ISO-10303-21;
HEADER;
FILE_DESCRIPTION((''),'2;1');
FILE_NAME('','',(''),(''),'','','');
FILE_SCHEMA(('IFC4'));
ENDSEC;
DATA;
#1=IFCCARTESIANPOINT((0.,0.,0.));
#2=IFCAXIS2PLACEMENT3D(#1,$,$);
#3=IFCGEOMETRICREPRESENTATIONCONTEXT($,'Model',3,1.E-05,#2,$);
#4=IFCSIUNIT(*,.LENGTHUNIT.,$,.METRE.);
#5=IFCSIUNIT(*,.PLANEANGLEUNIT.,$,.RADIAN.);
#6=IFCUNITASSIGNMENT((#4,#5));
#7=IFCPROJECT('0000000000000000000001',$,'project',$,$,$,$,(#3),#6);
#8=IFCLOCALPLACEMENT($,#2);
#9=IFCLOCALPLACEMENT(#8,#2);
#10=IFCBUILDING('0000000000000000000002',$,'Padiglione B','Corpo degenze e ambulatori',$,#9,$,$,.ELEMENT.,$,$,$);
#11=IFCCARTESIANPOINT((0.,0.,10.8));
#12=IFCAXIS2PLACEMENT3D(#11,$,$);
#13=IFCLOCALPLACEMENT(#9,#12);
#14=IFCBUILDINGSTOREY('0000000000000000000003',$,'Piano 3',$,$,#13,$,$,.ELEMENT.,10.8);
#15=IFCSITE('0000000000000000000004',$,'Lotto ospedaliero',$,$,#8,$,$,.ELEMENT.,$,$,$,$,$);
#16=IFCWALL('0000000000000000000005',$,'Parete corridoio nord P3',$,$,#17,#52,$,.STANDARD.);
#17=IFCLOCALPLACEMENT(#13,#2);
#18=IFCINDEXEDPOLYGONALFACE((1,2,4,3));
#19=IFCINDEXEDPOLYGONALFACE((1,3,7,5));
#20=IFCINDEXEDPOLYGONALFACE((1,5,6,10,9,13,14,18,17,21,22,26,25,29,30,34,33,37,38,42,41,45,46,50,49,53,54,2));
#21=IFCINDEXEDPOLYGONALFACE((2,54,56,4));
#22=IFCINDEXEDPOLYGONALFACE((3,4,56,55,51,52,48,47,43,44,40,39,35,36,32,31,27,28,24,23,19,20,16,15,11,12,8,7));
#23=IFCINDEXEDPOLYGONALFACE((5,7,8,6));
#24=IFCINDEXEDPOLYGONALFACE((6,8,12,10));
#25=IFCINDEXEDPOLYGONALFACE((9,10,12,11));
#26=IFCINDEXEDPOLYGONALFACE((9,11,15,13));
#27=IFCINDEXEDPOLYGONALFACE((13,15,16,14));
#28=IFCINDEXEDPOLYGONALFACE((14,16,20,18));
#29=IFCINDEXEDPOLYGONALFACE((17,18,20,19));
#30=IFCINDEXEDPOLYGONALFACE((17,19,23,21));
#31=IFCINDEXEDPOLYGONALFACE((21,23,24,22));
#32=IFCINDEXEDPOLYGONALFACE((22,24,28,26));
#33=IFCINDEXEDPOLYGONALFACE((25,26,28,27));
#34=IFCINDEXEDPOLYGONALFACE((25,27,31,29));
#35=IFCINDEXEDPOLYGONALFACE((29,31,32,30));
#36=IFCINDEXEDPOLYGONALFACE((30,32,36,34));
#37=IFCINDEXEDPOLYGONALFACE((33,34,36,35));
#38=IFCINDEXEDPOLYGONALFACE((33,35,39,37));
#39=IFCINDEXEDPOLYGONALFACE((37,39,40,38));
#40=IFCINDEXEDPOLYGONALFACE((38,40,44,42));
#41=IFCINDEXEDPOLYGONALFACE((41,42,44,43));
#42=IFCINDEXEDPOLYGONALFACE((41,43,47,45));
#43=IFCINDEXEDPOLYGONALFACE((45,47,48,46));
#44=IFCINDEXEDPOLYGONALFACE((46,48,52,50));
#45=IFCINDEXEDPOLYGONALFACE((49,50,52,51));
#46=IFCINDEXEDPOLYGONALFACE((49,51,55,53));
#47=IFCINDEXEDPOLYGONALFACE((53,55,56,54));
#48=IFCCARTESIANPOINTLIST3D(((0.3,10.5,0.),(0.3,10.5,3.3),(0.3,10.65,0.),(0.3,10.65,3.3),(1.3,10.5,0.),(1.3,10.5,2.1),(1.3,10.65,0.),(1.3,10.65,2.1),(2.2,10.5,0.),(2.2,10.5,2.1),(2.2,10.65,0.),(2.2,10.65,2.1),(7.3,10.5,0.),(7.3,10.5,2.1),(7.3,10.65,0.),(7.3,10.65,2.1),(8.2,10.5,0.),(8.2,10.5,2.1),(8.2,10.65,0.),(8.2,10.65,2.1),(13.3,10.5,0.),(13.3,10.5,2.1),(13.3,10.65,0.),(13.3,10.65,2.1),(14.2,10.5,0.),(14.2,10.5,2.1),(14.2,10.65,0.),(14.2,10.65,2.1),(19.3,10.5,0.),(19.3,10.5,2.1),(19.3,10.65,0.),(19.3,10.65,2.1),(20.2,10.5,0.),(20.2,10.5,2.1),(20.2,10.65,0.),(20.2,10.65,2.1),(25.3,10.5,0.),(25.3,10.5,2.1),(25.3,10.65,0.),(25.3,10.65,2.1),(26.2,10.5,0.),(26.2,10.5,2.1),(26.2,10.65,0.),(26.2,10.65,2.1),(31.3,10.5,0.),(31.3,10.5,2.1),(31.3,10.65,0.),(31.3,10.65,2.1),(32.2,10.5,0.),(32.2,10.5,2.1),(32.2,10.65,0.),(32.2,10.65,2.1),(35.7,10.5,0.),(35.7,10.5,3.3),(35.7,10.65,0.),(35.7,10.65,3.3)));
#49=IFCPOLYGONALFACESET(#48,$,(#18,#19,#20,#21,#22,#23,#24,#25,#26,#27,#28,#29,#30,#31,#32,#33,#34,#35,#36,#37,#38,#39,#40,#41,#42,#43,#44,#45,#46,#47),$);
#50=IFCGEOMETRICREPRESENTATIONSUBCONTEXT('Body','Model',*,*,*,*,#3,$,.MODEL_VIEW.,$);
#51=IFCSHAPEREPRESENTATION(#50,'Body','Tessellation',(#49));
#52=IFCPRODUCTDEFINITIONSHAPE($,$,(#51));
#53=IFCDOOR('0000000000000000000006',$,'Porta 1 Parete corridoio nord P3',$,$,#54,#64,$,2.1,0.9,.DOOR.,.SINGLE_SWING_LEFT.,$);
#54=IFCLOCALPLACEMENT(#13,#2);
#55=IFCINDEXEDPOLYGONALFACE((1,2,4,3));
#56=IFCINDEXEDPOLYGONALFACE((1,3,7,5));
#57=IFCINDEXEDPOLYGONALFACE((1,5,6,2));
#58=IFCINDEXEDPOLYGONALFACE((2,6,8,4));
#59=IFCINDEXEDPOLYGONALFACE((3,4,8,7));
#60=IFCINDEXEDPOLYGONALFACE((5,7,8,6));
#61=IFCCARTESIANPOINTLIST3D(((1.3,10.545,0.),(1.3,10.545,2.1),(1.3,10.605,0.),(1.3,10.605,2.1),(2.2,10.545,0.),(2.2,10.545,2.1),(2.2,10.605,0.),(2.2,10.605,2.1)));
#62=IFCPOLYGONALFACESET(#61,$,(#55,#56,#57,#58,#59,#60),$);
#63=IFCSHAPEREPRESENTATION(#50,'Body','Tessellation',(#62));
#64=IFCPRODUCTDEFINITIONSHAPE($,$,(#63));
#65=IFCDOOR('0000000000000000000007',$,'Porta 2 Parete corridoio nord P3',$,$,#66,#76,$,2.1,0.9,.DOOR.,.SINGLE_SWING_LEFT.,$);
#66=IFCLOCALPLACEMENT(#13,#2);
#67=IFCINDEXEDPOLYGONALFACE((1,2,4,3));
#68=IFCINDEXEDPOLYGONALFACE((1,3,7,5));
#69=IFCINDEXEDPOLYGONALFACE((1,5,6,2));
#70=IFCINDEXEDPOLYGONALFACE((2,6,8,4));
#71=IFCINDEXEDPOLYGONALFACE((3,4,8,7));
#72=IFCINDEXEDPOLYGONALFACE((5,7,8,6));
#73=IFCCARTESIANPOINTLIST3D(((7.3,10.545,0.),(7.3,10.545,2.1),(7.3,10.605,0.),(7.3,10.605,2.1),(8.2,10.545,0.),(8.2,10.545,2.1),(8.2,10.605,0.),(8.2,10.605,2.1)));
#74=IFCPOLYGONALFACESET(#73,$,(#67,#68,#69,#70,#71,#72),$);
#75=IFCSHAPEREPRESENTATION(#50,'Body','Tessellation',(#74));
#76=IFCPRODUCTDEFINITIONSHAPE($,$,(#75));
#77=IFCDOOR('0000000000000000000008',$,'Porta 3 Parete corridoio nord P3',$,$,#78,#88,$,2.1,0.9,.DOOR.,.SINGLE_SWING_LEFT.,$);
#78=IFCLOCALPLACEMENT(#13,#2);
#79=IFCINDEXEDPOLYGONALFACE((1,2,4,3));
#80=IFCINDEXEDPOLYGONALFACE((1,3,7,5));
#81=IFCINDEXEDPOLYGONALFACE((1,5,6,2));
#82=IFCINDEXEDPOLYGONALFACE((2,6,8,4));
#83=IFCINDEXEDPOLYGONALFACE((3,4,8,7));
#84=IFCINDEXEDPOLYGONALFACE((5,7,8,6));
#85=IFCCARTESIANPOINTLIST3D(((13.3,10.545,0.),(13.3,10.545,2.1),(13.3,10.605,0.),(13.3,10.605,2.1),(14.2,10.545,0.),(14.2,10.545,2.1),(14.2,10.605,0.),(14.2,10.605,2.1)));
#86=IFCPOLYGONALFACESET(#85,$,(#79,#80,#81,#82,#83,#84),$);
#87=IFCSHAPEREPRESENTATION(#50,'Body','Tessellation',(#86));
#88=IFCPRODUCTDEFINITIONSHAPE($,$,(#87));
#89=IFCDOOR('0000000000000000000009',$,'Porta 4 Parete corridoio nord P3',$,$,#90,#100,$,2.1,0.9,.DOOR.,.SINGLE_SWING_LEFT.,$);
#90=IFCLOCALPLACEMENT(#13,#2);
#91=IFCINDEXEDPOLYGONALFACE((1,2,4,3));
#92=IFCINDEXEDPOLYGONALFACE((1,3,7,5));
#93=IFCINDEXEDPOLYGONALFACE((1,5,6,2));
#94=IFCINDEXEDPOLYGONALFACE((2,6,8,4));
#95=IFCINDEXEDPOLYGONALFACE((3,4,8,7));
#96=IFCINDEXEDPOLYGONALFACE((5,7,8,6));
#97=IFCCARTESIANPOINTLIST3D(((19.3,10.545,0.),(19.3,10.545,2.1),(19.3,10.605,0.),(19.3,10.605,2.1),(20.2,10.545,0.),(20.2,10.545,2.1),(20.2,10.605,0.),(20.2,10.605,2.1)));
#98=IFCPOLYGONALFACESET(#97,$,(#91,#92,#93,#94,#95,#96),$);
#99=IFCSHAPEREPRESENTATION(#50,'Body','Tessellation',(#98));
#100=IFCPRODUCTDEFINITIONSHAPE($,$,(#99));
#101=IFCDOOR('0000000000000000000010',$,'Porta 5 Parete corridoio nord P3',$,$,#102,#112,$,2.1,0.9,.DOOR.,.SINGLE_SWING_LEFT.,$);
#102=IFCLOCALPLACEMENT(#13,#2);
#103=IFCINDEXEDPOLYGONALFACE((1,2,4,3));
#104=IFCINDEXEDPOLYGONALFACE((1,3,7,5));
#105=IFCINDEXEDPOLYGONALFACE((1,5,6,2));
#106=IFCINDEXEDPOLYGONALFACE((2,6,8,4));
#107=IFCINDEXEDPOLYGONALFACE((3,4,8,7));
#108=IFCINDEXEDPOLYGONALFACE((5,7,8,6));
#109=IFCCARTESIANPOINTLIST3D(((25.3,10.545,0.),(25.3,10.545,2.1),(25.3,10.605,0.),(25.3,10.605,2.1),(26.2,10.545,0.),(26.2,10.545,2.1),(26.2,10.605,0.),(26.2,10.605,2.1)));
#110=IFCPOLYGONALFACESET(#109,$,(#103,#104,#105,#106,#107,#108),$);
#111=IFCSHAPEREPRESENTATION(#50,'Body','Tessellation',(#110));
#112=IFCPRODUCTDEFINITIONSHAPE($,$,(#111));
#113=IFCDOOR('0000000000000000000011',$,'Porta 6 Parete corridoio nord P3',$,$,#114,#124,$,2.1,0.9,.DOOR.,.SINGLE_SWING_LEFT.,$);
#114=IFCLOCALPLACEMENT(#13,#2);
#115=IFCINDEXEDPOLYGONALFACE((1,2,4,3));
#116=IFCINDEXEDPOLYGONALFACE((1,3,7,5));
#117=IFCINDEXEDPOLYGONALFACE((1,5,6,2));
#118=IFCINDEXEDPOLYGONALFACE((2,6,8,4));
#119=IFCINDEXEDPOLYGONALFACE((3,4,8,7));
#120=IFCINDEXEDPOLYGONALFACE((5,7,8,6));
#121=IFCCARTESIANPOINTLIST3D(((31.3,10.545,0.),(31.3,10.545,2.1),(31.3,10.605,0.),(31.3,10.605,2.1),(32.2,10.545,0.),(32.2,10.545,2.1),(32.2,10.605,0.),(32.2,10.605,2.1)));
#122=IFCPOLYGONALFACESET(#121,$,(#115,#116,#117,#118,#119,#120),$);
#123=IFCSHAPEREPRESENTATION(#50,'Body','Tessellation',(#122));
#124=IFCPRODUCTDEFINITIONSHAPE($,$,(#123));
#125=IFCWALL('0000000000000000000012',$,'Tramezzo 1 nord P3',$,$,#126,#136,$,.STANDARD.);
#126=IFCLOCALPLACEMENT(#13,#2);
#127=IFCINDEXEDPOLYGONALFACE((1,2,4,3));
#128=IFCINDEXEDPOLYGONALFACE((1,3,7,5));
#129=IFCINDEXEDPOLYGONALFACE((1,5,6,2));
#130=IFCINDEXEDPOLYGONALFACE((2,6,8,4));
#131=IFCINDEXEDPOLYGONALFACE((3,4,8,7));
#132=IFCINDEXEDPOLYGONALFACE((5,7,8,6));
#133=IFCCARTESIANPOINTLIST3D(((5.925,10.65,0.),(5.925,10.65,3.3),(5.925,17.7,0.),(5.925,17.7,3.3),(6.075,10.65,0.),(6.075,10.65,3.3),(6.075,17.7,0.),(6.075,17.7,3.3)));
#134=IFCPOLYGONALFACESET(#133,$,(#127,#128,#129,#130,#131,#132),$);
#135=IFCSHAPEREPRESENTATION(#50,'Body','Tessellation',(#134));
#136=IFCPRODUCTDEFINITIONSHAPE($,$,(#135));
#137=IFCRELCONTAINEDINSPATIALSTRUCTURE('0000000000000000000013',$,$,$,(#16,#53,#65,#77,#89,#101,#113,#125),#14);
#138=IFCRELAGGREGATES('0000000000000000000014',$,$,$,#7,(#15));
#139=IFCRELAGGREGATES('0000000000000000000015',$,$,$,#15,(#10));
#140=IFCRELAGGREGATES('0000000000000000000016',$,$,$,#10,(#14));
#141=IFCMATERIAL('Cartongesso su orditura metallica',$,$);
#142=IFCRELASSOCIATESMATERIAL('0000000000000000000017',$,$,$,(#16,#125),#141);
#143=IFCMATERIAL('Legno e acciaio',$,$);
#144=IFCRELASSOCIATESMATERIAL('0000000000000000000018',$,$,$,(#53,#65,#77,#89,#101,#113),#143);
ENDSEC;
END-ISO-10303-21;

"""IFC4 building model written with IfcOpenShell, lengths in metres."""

from ifc_helpers import new_model, si_unit, frame, frame_2d, origin, place, context, subcontext, project, spatial, rectangle, extrude, material, element, fill, save


model = new_model("IFC4")

# Units and contexts
model_context = context("Model", 3, precision=1e-05, world=origin())
body_context = subcontext(model_context, "Body", "Model", "MODEL_VIEW")
ifc_project = project(units=[si_unit("LENGTHUNIT", "METRE"), si_unit("PLANEANGLEUNIT", "RADIAN")], contexts=[model_context])

# Site, building, storey
site_placement = place(None, origin())
site = spatial("IfcSite", under=ifc_project, at=site_placement, Name="Lotto ospedaliero", CompositionType="ELEMENT")
building_placement = place(site_placement, origin())
building = spatial("IfcBuilding", under=site, at=building_placement, Name="Padiglione B", Description="Corpo degenze e ambulatori", CompositionType="ELEMENT")
storey_placement = place(building_placement, frame((0.0, 0.0, 10.8)))
storey = spatial("IfcBuildingStorey", under=building, at=storey_placement, Name="Piano 3", CompositionType="ELEMENT", Elevation=10.8)

# Wall, openings, doors
ifc_material_1 = material(Name="Cartongesso su orditura metallica")
ifc_material_2 = material(Name="Legno e acciaio")
wall_1_placement = place(storey_placement, frame((0.3, 10.5, 0.0)))
wall_1 = element("IfcWall", 1, at=wall_1_placement, inside=storey, material=ifc_material_1, Name="Parete corridoio nord P3", PredefinedType="STANDARD", context=body_context, shape_type="SweptSolid", body=[
    extrude(rectangle(XDim=35.4, YDim=0.15, at=frame_2d((17.7, 0.075))), origin(), (0.0, 0.0, 1.0), 3.3),
])
opening_1_placement = place(wall_1_placement, frame((1.0, -0.1, 0.0)))
opening_1 = element("IfcOpeningElement", 2, at=opening_1_placement, cuts=wall_1, PredefinedType="OPENING", context=body_context, shape_type="SweptSolid", body=[
    extrude(rectangle(XDim=0.9, YDim=0.35, at=frame_2d((0.45, 0.175))), origin(), (0.0, 0.0, 1.0), 2.1),
])
opening_2_placement = place(wall_1_placement, frame((7.0, -0.1, 0.0)))
opening_2 = element("IfcOpeningElement", 3, at=opening_2_placement, cuts=wall_1, PredefinedType="OPENING", context=body_context, shape_type="SweptSolid", body=[
    extrude(rectangle(XDim=0.9, YDim=0.35, at=frame_2d((0.45, 0.175))), origin(), (0.0, 0.0, 1.0), 2.1),
])
opening_3_placement = place(wall_1_placement, frame((13.0, -0.1, 0.0)))
opening_3 = element("IfcOpeningElement", 4, at=opening_3_placement, cuts=wall_1, PredefinedType="OPENING", context=body_context, shape_type="SweptSolid", body=[
    extrude(rectangle(XDim=0.9, YDim=0.35, at=frame_2d((0.45, 0.175))), origin(), (0.0, 0.0, 1.0), 2.1),
])
opening_4_placement = place(wall_1_placement, frame((19.0, -0.1, 0.0)))
opening_4 = element("IfcOpeningElement", 5, at=opening_4_placement, cuts=wall_1, PredefinedType="OPENING", context=body_context, shape_type="SweptSolid", body=[
    extrude(rectangle(XDim=0.9, YDim=0.35, at=frame_2d((0.45, 0.175))), origin(), (0.0, 0.0, 1.0), 2.1),
])
opening_5_placement = place(wall_1_placement, frame((25.0, -0.1, 0.0)))
opening_5 = element("IfcOpeningElement", 6, at=opening_5_placement, cuts=wall_1, PredefinedType="OPENING", context=body_context, shape_type="SweptSolid", body=[
    extrude(rectangle(XDim=0.9, YDim=0.35, at=frame_2d((0.45, 0.175))), origin(), (0.0, 0.0, 1.0), 2.1),
])
opening_6_placement = place(wall_1_placement, frame((31.0, -0.1, 0.0)))
opening_6 = element("IfcOpeningElement", 7, at=opening_6_placement, cuts=wall_1, PredefinedType="OPENING", context=body_context, shape_type="SweptSolid", body=[
    extrude(rectangle(XDim=0.9, YDim=0.35, at=frame_2d((0.45, 0.175))), origin(), (0.0, 0.0, 1.0), 2.1),
])
door_1_placement = place(wall_1_placement, frame((1.0, 0.045, 0.0)))
door_1 = element("IfcDoor", 8, at=door_1_placement, inside=storey, material=ifc_material_2, Name="Porta 1 Parete corridoio nord P3", OperationType="SINGLE_SWING_LEFT", OverallHeight=2.1, OverallWidth=0.9, PredefinedType="DOOR", context=body_context, shape_type="SweptSolid", body=[
    extrude(rectangle(XDim=0.9, YDim=0.06, at=frame_2d((0.45, 0.03))), origin(), (0.0, 0.0, 1.0), 2.1),
])
fill(opening_1, door_1)
door_2_placement = place(wall_1_placement, frame((7.0, 0.045, 0.0)))
door_2 = element("IfcDoor", 9, at=door_2_placement, inside=storey, material=ifc_material_2, Name="Porta 2 Parete corridoio nord P3", OperationType="SINGLE_SWING_LEFT", OverallHeight=2.1, OverallWidth=0.9, PredefinedType="DOOR", context=body_context, shape_type="SweptSolid", body=[
    extrude(rectangle(XDim=0.9, YDim=0.06, at=frame_2d((0.45, 0.03))), origin(), (0.0, 0.0, 1.0), 2.1),
])
fill(opening_2, door_2)
door_3_placement = place(wall_1_placement, frame((13.0, 0.045, 0.0)))
door_3 = element("IfcDoor", 10, at=door_3_placement, inside=storey, material=ifc_material_2, Name="Porta 3 Parete corridoio nord P3", OperationType="SINGLE_SWING_LEFT", OverallHeight=2.1, OverallWidth=0.9, PredefinedType="DOOR", context=body_context, shape_type="SweptSolid", body=[
    extrude(rectangle(XDim=0.9, YDim=0.06, at=frame_2d((0.45, 0.03))), origin(), (0.0, 0.0, 1.0), 2.1),
])
fill(opening_3, door_3)
door_4_placement = place(wall_1_placement, frame((19.0, 0.045, 0.0)))
door_4 = element("IfcDoor", 11, at=door_4_placement, inside=storey, material=ifc_material_2, Name="Porta 4 Parete corridoio nord P3", OperationType="SINGLE_SWING_LEFT", OverallHeight=2.1, OverallWidth=0.9, PredefinedType="DOOR", context=body_context, shape_type="SweptSolid", body=[
    extrude(rectangle(XDim=0.9, YDim=0.06, at=frame_2d((0.45, 0.03))), origin(), (0.0, 0.0, 1.0), 2.1),
])
fill(opening_4, door_4)
door_5_placement = place(wall_1_placement, frame((25.0, 0.045, 0.0)))
door_5 = element("IfcDoor", 12, at=door_5_placement, inside=storey, material=ifc_material_2, Name="Porta 5 Parete corridoio nord P3", OperationType="SINGLE_SWING_LEFT", OverallHeight=2.1, OverallWidth=0.9, PredefinedType="DOOR", context=body_context, shape_type="SweptSolid", body=[
    extrude(rectangle(XDim=0.9, YDim=0.06, at=frame_2d((0.45, 0.03))), origin(), (0.0, 0.0, 1.0), 2.1),
])
fill(opening_5, door_5)
door_6_placement = place(wall_1_placement, frame((31.0, 0.045, 0.0)))
door_6 = element("IfcDoor", 13, at=door_6_placement, inside=storey, material=ifc_material_2, Name="Porta 6 Parete corridoio nord P3", OperationType="SINGLE_SWING_LEFT", OverallHeight=2.1, OverallWidth=0.9, PredefinedType="DOOR", context=body_context, shape_type="SweptSolid", body=[
    extrude(rectangle(XDim=0.9, YDim=0.06, at=frame_2d((0.45, 0.03))), origin(), (0.0, 0.0, 1.0), 2.1),
])
fill(opening_6, door_6)

# Wall
wall_2_placement = place(storey_placement, frame((5.925, 10.65, 0.0)))
element("IfcWall", 14, at=wall_2_placement, inside=storey, material=ifc_material_1, Name="Tramezzo 1 nord P3", PredefinedType="STANDARD", context=body_context, shape_type="SweptSolid", body=[
    extrude(rectangle(XDim=0.15, YDim=7.05, at=frame_2d((0.075, 3.525))), origin(), (0.0, 0.0, 1.0), 3.3),
])

save(model, "model.ifc")
